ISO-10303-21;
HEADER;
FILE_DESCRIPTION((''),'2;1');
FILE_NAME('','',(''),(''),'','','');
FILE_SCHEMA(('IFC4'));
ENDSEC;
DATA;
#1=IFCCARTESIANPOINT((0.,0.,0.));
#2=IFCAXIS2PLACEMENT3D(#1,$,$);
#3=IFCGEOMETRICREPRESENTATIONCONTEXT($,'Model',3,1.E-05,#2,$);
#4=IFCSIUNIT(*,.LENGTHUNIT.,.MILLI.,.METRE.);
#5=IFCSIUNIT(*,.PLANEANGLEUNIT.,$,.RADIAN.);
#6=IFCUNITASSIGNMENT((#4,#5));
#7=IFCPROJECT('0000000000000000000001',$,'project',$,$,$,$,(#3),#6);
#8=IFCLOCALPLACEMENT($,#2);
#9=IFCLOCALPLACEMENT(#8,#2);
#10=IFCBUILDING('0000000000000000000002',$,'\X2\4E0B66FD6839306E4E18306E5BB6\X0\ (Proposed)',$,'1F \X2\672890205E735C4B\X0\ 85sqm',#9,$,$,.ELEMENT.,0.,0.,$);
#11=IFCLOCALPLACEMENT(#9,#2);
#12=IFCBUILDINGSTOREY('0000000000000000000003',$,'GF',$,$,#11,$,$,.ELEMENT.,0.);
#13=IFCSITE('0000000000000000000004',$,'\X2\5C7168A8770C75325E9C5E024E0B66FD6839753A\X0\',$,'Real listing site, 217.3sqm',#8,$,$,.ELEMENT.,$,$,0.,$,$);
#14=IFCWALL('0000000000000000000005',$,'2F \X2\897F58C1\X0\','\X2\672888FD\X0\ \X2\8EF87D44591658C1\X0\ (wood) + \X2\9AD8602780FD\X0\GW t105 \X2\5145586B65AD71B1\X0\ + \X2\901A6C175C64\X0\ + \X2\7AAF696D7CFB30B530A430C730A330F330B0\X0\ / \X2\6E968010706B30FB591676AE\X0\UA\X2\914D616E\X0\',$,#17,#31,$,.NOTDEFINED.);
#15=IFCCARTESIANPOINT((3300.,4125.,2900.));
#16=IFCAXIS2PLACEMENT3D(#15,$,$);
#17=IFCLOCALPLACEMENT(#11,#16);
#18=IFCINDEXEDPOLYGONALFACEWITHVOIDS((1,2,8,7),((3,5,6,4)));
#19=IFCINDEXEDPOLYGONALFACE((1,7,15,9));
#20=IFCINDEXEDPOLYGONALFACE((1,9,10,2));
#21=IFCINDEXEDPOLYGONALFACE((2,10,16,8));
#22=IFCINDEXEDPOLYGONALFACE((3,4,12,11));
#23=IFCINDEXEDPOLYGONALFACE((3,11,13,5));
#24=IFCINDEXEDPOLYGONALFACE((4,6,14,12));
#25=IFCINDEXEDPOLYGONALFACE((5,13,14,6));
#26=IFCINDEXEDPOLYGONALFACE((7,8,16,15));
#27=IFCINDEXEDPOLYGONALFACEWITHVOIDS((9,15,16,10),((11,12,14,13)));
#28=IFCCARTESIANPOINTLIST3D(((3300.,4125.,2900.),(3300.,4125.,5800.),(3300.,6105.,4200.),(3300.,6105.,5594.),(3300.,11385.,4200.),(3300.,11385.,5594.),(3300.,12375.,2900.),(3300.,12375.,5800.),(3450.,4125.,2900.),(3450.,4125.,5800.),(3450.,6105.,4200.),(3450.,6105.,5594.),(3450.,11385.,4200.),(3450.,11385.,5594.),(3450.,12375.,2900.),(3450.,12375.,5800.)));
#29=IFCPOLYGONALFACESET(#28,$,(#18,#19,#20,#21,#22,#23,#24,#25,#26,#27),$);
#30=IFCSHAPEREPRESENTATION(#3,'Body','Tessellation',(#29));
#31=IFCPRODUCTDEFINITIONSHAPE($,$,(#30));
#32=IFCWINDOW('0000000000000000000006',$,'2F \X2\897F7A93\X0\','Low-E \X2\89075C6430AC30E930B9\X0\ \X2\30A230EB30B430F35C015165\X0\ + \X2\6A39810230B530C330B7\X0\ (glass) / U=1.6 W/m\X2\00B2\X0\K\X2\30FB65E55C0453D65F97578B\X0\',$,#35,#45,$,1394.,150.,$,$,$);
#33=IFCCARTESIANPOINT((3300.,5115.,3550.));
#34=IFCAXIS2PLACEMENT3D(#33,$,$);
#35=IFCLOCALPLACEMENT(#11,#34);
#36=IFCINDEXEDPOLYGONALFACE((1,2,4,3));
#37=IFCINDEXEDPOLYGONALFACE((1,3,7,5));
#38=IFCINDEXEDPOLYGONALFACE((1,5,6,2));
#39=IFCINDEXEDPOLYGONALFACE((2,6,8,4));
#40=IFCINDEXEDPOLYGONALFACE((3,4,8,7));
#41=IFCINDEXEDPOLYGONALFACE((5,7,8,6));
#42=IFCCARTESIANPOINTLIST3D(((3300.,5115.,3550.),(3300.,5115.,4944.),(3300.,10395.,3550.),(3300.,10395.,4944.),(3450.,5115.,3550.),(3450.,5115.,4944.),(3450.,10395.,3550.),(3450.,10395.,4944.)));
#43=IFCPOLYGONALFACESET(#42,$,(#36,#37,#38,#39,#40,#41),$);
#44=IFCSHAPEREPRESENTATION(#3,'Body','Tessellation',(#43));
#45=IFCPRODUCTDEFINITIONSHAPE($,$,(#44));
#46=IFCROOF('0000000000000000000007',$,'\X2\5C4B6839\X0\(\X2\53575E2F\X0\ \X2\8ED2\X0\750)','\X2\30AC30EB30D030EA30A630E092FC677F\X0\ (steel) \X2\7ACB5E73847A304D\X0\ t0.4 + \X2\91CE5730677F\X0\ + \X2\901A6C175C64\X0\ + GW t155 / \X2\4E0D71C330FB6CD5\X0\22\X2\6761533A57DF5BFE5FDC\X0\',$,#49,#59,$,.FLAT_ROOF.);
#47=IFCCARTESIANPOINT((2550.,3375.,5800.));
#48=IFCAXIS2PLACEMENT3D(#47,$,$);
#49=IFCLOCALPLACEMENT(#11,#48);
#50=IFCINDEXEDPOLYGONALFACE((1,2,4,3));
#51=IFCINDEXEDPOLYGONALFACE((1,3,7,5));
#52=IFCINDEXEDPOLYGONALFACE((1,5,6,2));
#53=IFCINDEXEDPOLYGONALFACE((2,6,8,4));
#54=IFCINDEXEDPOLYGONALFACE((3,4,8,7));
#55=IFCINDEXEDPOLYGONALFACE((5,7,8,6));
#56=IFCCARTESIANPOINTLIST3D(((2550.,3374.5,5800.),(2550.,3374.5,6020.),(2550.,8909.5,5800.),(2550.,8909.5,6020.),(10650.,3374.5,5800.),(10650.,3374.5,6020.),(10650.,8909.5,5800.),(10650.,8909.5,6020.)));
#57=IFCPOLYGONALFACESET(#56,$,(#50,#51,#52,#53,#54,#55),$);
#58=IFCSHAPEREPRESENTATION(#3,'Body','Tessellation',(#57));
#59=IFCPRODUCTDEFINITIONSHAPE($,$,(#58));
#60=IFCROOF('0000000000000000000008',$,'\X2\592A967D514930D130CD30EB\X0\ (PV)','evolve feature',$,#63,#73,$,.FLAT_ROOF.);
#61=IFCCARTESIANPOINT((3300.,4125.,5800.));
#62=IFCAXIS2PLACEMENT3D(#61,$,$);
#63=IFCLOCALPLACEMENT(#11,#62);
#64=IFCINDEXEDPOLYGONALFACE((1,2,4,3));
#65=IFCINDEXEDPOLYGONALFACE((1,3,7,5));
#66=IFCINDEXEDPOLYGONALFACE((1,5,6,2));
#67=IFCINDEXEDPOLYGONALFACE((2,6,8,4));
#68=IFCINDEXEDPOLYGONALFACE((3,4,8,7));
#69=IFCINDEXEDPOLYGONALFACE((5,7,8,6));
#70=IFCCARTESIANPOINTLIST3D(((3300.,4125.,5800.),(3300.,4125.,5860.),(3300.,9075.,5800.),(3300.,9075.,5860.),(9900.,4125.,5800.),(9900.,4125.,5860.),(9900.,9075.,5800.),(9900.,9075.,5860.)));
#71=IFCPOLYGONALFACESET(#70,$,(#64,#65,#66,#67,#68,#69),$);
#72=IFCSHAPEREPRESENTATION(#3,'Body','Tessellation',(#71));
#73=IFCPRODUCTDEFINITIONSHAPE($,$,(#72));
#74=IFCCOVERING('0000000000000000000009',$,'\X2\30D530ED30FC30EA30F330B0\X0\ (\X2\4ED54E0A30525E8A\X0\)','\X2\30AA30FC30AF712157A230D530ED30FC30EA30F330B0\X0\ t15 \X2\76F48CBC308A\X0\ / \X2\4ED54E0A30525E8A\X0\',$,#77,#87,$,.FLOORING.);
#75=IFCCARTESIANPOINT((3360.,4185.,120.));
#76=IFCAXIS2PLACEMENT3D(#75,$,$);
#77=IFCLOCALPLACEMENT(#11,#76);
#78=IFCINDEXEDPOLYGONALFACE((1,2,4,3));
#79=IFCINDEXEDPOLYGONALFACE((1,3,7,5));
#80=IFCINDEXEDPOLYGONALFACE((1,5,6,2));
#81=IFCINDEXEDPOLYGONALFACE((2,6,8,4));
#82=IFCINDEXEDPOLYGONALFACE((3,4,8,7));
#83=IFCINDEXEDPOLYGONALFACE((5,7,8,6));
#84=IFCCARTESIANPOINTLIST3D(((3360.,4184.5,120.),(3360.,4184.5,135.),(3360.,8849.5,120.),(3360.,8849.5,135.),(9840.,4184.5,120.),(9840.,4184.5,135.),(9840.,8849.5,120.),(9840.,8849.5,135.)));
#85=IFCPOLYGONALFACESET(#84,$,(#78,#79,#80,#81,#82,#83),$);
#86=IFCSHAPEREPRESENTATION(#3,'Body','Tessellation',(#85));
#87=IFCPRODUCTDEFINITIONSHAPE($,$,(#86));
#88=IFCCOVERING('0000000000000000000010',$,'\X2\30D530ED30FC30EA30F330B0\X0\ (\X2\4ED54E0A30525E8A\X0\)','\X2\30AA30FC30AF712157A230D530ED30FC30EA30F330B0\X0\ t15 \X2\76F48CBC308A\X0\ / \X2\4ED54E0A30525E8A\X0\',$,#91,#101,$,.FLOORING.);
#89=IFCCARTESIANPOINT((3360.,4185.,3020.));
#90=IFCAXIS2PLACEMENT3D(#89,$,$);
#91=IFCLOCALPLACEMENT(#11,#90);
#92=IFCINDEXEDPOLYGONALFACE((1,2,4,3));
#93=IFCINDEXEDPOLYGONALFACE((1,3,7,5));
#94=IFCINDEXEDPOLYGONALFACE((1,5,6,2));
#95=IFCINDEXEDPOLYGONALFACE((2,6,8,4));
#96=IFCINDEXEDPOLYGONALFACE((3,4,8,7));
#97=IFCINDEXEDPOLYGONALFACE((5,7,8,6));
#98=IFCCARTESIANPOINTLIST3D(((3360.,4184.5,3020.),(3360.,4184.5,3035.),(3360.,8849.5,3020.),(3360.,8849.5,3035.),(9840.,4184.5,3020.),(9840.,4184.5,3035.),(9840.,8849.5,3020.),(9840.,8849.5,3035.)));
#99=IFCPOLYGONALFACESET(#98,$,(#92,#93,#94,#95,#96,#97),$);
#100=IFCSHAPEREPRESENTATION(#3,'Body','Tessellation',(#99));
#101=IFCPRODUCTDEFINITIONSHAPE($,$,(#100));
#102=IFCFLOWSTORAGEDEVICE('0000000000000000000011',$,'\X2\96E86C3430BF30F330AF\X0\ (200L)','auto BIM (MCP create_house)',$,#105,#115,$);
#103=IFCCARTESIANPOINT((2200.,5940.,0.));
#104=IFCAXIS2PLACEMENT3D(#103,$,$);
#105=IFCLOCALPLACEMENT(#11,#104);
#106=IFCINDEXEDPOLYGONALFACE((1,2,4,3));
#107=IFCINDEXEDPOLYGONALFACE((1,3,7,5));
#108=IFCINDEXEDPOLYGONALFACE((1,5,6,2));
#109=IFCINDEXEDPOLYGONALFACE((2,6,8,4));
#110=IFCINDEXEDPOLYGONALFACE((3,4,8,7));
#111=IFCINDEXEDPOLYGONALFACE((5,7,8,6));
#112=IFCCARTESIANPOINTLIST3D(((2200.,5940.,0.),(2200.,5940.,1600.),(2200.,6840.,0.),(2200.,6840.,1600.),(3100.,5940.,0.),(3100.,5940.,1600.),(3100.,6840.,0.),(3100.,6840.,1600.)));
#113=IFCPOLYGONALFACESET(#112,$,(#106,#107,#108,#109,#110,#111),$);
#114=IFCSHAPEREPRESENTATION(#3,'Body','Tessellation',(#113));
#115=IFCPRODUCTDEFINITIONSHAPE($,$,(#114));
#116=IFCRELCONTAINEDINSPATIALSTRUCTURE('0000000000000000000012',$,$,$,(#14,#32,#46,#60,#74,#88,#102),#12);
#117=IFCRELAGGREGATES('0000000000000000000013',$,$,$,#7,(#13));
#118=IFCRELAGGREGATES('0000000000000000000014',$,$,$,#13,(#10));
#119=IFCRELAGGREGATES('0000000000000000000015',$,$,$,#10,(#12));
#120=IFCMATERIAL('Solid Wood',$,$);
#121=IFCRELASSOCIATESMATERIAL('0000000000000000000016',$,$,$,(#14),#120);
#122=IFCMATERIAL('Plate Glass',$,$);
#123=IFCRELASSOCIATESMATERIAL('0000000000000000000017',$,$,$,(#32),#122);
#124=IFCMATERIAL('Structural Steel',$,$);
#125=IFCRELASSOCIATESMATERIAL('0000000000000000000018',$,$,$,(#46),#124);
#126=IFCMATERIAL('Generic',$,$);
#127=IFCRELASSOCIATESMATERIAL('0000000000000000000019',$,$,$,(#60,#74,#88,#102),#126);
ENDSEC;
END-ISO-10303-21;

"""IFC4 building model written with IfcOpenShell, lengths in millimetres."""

from ifc_helpers import new_model, si_unit, frame, frame_2d, origin, place, context, project, spatial, rectangle, extrude, material, element, fill, save


model = new_model("IFC4")

# Units and contexts
model_context = context("Model", 3, precision=1e-05, world=origin())
ifc_project = project(units=[si_unit("LENGTHUNIT", "METRE", prefix="MILLI"), si_unit("PLANEANGLEUNIT", "RADIAN")], contexts=[model_context])

# Site, building, storey
site_placement = place(None, origin())
site = spatial("IfcSite", under=ifc_project, at=site_placement, Name="山梨県甲府市下曽根町", ObjectType="Real listing site, 217.3sqm", CompositionType="ELEMENT", RefElevation=0.0)
building_placement = place(site_placement, origin())
building = spatial("IfcBuilding", under=site, at=building_placement, Name="下曽根の丘の家 (Proposed)", ObjectType="1F 木造平屋 85sqm", CompositionType="ELEMENT", ElevationOfRefHeight=0.0, ElevationOfTerrain=0.0)
storey_placement = place(building_placement, origin())
storey = spatial("IfcBuildingStorey", under=building, at=storey_placement, Name="GF", CompositionType="ELEMENT", Elevation=0.0)

# Shared definitions
ifc_material_1 = material(Name="Solid Wood")
ifc_material_2 = material(Name="Generic")

# Shared definitions
ifc_material_3 = material(Name="Plate Glass")

# Wall, opening, window
wall_1_placement = place(storey_placement, frame((3300.0, 4125.0, 2900.0)))
wall_1 = element("IfcWall", 1, at=wall_1_placement, inside=storey, material=ifc_material_1, Name="2F 西壁", Description="木製 軸組外壁 (wood) + 高性能GW t105 充填断熱 + 通気層 + 窯業系サイディング / 準耐火・外皮UA配慮", PredefinedType="NOTDEFINED", context=model_context, shape_type="SweptSolid", body=[
    extrude(rectangle(XDim=150.0, YDim=8250.0, at=frame_2d((75.0, 4125.0))), frame((3300.0, 4125.0, 2900.0)), (0.0, 0.0, 1.0), 2900.0),
])
opening_1_placement = place(storey_placement, frame((3300.0, 5115.0, 3550.0)))
opening_1 = element("IfcOpeningElement", 2, at=opening_1_placement, cuts=wall_1, PredefinedType="NOTDEFINED", context=model_context, shape_type="SweptSolid", body=[
    extrude(rectangle(XDim=150.0, YDim=5280.0, at=frame_2d((75.0, 2640.0))), frame((3300.0, 5115.0, 3550.0)), (0.0, 0.0, 1.0), 1394.0),
])
window_1_placement = place(storey_placement, frame((3300.0, 5115.0, 3550.0)))
window_1 = element("IfcWindow", 3, at=window_1_placement, inside=storey, material=ifc_material_3, Name="2F 西窓", Description="Low-E 複層ガラス アルゴン封入 + 樹脂サッシ (glass) / U=1.6 W/m²K・日射取得型", OverallHeight=1394.0, OverallWidth=150.0, context=model_context, shape_type="SweptSolid", body=[
    extrude(rectangle(XDim=150.0, YDim=5280.0, at=frame_2d((75.0, 2640.0))), frame((3300.0, 5115.0, 3550.0)), (0.0, 0.0, 1.0), 1394.0),
])
fill(opening_1, window_1)

# Roofs
ifc_material_4 = material(Name="Structural Steel")
for number, where, name in (
    (4, (2550.0, 3375.0, 5800.0), "屋根(南帯 軒750)"),
):
    element("IfcRoof", number, at=place(storey_placement, frame(where)), inside=storey, material=ifc_material_4, Name=name, Description="ガルバリウム鋼板 (steel) 立平葺き t0.4 + 野地板 + 通気層 + GW t155 / 不燃・法22条区域対応", PredefinedType="FLAT_ROOF", context=model_context, shape_type="SweptSolid", body=[
        extrude(rectangle(XDim=8100.0, YDim=5535.0, at=frame_2d((4050.0, 2767.0))), frame((2550.0, 3375.0, 5800.0)), (0.0, 0.0, 1.0), 220.0),
    ])
roof_placement = place(storey_placement, frame((3300.0, 4125.0, 5800.0)))
element("IfcRoof", 5, at=roof_placement, inside=storey, material=ifc_material_2, Name="太陽光パネル (PV)", Description="evolve feature", PredefinedType="FLAT_ROOF", context=model_context, shape_type="SweptSolid", body=[
    extrude(rectangle(XDim=6600.0, YDim=4950.0, at=frame_2d((3300.0, 2475.0))), frame((3300.0, 4125.0, 5800.0)), (0.0, 0.0, 1.0), 60.0),
])

# Coverings
covering_1_placement = place(storey_placement, frame((3360.0, 4185.0, 120.0)))
element("IfcCovering", 6, at=covering_1_placement, inside=storey, material=ifc_material_2, Name="フローリング (仕上げ床)", Description="オーク無垢フローリング t15 直貼り / 仕上げ床", PredefinedType="FLOORING", context=model_context, shape_type="SweptSolid", body=[
    extrude(rectangle(XDim=6480.0, YDim=4665.0, at=frame_2d((3240.0, 2332.0))), frame((3360.0, 4185.0, 120.0)), (0.0, 0.0, 1.0), 15.0),
])
covering_2_placement = place(storey_placement, frame((3360.0, 4185.0, 3020.0)))
element("IfcCovering", 7, at=covering_2_placement, inside=storey, material=ifc_material_2, Name="フローリング (仕上げ床)", Description="オーク無垢フローリング t15 直貼り / 仕上げ床", PredefinedType="FLOORING", context=model_context, shape_type="SweptSolid", body=[
    extrude(rectangle(XDim=6480.0, YDim=4665.0, at=frame_2d((3240.0, 2332.0))), frame((3360.0, 4185.0, 3020.0)), (0.0, 0.0, 1.0), 15.0),
])

# Flow storage device
flow_storage_device_placement = place(storey_placement, frame((2200.0, 5940.0, 0.0)))
element("IfcFlowStorageDevice", 8, at=flow_storage_device_placement, inside=storey, material=ifc_material_2, Name="雨水タンク (200L)", Description="auto BIM (MCP create_house)", context=model_context, shape_type="SweptSolid", body=[
    extrude(rectangle(XDim=900.0, YDim=900.0, at=frame_2d((450.0, 450.0))), frame((2200.0, 5940.0, 0.0)), (0.0, 0.0, 1.0), 1600.0),
])

save(model, "model.ifc")
